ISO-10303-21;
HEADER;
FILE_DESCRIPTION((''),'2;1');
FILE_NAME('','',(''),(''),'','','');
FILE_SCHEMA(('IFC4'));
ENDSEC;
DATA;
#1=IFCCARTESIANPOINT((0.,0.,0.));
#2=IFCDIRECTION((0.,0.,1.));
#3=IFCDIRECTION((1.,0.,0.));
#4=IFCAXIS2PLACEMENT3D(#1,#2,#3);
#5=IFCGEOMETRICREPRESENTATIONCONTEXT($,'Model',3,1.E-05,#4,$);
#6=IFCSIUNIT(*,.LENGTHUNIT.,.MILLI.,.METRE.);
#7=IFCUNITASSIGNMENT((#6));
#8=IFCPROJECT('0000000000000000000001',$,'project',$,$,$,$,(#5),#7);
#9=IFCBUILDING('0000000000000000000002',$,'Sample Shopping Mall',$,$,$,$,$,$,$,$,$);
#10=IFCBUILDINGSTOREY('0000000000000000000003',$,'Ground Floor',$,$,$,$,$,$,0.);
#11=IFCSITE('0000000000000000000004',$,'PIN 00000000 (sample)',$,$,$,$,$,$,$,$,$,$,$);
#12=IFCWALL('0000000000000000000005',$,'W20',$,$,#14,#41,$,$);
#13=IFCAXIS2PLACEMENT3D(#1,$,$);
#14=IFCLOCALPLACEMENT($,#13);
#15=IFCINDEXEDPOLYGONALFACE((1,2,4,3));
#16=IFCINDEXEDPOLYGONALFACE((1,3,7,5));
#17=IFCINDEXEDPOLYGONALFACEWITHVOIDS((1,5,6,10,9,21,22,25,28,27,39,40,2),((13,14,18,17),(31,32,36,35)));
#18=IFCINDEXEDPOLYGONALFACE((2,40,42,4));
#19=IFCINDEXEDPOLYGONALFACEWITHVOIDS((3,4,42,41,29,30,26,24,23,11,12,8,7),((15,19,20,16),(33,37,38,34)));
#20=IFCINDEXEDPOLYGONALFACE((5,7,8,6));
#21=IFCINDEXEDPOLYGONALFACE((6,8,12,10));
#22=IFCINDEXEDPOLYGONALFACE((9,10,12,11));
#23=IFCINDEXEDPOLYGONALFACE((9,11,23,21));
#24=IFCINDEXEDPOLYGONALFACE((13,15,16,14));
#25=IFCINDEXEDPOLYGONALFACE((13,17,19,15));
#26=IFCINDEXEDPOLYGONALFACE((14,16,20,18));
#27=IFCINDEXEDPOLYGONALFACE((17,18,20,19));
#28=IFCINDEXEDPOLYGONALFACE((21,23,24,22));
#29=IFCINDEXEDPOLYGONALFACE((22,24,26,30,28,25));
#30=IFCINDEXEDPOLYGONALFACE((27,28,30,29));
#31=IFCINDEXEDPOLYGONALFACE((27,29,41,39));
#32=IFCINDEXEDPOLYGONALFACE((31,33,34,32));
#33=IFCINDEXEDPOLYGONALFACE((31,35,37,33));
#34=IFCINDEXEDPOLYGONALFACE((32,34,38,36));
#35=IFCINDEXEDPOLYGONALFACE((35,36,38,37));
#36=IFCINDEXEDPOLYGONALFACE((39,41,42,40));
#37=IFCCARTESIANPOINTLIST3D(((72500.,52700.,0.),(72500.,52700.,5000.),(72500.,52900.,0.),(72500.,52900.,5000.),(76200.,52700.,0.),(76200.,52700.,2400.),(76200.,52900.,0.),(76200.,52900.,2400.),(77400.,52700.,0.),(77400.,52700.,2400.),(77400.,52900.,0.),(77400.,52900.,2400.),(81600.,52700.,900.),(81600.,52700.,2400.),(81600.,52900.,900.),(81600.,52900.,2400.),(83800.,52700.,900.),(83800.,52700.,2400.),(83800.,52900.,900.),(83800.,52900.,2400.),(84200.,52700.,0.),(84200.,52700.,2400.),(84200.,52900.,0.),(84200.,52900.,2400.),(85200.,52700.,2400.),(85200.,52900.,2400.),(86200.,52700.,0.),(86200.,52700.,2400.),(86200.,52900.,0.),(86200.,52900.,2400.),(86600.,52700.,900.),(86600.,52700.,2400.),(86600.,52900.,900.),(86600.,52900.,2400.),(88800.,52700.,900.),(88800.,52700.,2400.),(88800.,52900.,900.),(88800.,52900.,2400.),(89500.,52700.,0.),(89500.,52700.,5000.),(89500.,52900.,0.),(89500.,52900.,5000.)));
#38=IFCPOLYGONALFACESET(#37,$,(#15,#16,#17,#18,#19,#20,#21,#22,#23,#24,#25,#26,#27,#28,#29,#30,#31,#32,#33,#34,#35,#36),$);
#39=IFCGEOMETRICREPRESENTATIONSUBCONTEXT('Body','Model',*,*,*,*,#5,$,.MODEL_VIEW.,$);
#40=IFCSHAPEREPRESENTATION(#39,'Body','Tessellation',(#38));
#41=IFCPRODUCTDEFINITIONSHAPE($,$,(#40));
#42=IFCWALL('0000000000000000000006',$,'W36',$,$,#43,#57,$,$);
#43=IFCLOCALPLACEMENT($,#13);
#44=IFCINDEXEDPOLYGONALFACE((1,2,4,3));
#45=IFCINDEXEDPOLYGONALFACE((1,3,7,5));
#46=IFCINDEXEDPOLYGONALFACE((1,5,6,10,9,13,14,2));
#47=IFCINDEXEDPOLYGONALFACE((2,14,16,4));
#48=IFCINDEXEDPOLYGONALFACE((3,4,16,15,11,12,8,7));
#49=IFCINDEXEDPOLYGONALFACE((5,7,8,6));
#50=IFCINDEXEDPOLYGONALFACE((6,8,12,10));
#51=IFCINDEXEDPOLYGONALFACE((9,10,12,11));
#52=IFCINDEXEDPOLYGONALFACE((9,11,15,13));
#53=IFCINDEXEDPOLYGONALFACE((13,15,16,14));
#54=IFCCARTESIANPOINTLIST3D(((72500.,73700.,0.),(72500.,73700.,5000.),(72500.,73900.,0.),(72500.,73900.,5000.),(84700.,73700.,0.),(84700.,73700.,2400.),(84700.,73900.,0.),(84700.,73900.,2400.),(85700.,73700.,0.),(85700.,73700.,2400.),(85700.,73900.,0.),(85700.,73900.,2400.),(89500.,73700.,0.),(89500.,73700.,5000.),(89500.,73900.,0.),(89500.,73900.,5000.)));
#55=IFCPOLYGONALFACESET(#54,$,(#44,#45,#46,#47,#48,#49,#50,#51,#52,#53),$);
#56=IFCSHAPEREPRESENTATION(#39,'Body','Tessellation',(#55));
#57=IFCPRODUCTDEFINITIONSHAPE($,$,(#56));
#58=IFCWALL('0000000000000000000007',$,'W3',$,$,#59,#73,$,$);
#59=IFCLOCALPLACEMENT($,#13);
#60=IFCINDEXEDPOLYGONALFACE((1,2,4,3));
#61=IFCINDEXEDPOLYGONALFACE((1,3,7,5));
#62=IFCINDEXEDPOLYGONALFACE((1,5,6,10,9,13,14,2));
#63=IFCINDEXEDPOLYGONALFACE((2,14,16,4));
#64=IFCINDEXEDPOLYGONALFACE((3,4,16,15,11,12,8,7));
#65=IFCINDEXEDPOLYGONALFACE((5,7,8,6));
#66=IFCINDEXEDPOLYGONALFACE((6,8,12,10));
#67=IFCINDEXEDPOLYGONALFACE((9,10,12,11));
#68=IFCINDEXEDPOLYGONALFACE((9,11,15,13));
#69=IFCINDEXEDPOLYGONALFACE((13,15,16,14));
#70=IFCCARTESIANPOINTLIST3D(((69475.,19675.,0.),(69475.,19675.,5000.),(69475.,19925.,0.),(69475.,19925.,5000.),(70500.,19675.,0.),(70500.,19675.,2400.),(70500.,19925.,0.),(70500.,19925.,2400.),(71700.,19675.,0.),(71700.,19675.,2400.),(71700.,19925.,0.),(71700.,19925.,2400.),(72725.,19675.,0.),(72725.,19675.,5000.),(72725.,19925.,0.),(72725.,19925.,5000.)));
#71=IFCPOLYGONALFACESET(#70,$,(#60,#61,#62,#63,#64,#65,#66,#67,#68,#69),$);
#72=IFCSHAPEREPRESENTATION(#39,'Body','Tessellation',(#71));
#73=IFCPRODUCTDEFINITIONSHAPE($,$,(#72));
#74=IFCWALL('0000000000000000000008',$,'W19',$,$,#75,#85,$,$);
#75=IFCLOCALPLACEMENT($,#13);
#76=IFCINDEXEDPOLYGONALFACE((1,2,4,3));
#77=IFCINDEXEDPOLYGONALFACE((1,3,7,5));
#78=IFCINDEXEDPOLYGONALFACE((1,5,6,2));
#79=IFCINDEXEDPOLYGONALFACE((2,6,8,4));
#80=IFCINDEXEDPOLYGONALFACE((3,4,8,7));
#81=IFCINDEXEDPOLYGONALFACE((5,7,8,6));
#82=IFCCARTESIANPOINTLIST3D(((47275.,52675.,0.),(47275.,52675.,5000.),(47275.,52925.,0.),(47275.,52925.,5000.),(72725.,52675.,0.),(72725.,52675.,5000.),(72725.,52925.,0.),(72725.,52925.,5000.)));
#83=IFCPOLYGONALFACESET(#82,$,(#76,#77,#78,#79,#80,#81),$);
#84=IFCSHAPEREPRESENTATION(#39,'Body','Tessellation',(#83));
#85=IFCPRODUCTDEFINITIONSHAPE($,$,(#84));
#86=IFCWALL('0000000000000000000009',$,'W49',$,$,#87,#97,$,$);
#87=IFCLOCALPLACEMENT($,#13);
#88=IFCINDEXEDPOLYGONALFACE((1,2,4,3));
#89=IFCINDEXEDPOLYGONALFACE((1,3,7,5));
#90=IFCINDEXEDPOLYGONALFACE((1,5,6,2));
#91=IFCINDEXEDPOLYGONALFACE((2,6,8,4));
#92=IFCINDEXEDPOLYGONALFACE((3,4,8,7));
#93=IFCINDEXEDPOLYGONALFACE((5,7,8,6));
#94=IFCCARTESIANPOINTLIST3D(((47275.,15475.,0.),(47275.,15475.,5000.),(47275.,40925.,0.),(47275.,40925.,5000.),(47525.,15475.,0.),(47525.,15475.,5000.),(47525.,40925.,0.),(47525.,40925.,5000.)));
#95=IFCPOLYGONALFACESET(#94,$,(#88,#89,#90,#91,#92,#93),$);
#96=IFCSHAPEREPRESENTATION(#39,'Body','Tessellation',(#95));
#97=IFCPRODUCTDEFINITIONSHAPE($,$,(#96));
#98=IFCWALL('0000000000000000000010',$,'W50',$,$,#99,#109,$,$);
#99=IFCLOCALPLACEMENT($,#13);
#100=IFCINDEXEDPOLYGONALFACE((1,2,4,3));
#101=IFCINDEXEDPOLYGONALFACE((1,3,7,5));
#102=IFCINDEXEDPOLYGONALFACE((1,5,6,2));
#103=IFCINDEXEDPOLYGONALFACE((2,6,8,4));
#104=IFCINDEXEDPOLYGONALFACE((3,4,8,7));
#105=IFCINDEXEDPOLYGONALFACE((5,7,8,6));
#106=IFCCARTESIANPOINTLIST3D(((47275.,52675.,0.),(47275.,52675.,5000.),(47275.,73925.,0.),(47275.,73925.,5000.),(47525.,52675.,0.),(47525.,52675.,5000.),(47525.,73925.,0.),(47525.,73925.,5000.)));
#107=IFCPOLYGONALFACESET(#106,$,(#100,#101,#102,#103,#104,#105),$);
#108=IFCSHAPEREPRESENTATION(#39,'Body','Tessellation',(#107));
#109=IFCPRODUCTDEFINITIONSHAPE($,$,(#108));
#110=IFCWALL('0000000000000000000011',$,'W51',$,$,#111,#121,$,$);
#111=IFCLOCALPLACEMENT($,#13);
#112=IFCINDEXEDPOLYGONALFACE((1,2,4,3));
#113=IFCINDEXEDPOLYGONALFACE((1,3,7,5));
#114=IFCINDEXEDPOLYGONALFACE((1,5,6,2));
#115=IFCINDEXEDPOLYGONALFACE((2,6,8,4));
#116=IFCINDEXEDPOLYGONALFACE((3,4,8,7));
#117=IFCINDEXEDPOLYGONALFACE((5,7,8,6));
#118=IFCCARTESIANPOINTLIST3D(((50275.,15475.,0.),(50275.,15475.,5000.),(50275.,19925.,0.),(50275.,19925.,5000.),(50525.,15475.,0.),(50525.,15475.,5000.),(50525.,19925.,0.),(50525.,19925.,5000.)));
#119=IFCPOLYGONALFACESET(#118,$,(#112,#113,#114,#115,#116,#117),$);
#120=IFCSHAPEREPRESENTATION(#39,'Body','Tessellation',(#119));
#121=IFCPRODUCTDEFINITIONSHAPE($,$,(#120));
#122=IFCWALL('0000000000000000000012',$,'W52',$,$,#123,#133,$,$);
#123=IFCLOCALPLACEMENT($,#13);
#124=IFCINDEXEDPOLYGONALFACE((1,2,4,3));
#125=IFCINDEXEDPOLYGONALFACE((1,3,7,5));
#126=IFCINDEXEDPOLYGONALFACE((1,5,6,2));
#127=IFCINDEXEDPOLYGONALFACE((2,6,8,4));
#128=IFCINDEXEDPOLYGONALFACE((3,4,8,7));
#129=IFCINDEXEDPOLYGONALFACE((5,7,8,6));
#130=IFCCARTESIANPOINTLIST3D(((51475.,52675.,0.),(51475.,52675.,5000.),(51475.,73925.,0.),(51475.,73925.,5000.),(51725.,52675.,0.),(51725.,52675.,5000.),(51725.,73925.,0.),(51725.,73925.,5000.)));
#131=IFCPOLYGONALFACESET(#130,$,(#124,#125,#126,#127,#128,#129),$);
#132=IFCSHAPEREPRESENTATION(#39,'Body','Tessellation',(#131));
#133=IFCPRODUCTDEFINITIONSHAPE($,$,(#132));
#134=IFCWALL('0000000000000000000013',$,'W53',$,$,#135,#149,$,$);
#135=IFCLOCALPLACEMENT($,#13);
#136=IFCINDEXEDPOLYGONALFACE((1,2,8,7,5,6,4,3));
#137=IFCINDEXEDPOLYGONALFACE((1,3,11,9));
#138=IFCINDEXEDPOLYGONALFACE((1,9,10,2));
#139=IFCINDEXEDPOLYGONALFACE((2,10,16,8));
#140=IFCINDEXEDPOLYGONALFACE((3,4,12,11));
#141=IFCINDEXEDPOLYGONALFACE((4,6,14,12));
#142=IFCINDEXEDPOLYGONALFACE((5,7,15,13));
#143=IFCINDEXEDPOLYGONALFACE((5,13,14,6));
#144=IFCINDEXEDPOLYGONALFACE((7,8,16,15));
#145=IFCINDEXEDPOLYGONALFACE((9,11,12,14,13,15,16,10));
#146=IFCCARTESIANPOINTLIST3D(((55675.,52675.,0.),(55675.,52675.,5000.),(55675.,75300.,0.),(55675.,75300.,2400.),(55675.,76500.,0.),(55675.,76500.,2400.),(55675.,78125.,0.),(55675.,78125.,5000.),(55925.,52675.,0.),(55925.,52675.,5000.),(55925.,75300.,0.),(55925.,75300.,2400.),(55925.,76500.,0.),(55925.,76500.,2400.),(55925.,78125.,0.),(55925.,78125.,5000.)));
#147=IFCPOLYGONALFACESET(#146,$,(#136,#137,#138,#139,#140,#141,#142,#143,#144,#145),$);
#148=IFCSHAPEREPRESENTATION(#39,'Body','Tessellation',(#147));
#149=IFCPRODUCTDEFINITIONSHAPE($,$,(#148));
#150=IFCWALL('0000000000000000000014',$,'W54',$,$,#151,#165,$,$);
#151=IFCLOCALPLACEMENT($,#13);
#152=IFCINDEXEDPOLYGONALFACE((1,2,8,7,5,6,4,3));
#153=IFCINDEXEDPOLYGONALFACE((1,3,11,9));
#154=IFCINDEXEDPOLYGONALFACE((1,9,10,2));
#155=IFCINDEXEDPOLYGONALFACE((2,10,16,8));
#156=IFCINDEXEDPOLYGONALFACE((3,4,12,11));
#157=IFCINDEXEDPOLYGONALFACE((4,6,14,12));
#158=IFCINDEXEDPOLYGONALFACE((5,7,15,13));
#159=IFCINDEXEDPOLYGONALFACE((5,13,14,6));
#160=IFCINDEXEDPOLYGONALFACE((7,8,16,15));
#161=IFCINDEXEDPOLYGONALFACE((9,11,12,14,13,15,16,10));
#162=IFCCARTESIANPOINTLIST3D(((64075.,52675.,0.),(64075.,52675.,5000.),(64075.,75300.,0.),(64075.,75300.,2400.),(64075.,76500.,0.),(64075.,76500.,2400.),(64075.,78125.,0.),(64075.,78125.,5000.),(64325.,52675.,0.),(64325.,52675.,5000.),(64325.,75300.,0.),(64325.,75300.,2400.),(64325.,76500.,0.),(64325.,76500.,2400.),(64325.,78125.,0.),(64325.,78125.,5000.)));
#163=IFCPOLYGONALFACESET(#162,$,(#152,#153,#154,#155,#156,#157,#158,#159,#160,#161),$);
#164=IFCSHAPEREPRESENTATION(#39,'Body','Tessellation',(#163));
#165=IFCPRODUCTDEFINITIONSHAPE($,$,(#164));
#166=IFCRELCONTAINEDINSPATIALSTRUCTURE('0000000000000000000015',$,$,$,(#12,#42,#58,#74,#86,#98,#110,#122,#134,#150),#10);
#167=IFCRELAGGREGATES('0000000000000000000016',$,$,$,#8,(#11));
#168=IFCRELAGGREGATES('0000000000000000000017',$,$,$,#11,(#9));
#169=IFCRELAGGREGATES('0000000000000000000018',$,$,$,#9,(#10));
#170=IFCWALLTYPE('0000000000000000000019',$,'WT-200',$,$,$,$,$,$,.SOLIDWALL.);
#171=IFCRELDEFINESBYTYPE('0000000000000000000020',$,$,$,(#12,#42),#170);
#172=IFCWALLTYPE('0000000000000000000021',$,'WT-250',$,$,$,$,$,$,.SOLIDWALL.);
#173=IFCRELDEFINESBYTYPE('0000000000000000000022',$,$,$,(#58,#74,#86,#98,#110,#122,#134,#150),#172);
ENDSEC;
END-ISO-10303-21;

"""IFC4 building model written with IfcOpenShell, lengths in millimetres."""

from ifc_helpers import new_model, si_unit, frame, origin_with_axes, place, context, subcontext, project, spatial, indexed_curve, outline, extrude, type_object, element, save


model = new_model("IFC4")

# Units and contexts
model_context = context("Model", 3, precision=1e-05, world=origin_with_axes())
body_context = subcontext(model_context, "Body", "Model", "MODEL_VIEW")
ifc_project = project(units=[si_unit("LENGTHUNIT", "METRE", prefix="MILLI")], contexts=[model_context])

# Site, building, storey
site = spatial("IfcSite", under=ifc_project, Name="PIN 00000000 (sample)")
building = spatial("IfcBuilding", under=site, Name="Sample Shopping Mall")
storey = spatial("IfcBuildingStorey", under=building, Name="Ground Floor", Elevation=0.0)

# Wall, openings
wall_type_1 = type_object("IfcWallType", Name="WT-200", PredefinedType="SOLIDWALL")
wall_1_placement = place(None, frame((72500.0, 52700.0, 0.0), z_axis=(0.0, 0.0, 1.0), x_axis=(1.0, 0.0, 0.0)))
wall_1 = element("IfcWall", 1, at=wall_1_placement, inside=storey, type_object=wall_type_1, Name="W20", context=body_context, shape_type="SweptSolid", body=[
    extrude(outline(indexed_curve([(0.0, 0.0), (0.0, 200.0), (17000.0, 200.0), (17000.0, 0.0), (0.0, 0.0)], self_intersect=False)), origin_with_axes(), (0.0, 0.0, 1.0), 5000.0),
])
opening_1_placement = place(wall_1_placement, frame((3700.0, -100.0, 0.0), z_axis=(0.0, 0.0, 1.0), x_axis=(1.0, 0.0, 0.0)))
element("IfcOpeningElement", 2, at=opening_1_placement, cuts=wall_1, context=body_context, shape_type="SweptSolid", body=[
    extrude(outline(indexed_curve([(0.0, 0.0), (0.0, 400.0), (1200.0, 400.0), (1200.0, 0.0), (0.0, 0.0)], self_intersect=False)), origin_with_axes(), (0.0, 0.0, 1.0), 2400.0),
])
opening_2_placement = place(wall_1_placement, frame((11700.0, -100.0, 0.0), z_axis=(0.0, 0.0, 1.0), x_axis=(1.0, 0.0, 0.0)))
element("IfcOpeningElement", 3, at=opening_2_placement, cuts=wall_1, context=body_context, shape_type="SweptSolid", body=[
    extrude(outline(indexed_curve([(0.0, 0.0), (0.0, 400.0), (1000.0, 400.0), (1000.0, 0.0), (0.0, 0.0)], self_intersect=False)), origin_with_axes(), (0.0, 0.0, 1.0), 2400.0),
])
opening_3_placement = place(wall_1_placement, frame((12700.0, -100.0, 0.0), z_axis=(0.0, 0.0, 1.0), x_axis=(1.0, 0.0, 0.0)))
element("IfcOpeningElement", 4, at=opening_3_placement, cuts=wall_1, context=body_context, shape_type="SweptSolid", body=[
    extrude(outline(indexed_curve([(0.0, 0.0), (0.0, 400.0), (1000.0, 400.0), (1000.0, 0.0), (0.0, 0.0)], self_intersect=False)), origin_with_axes(), (0.0, 0.0, 1.0), 2400.0),
])
opening_4_placement = place(wall_1_placement, frame((9100.0, -100.0, 900.0), z_axis=(0.0, 0.0, 1.0), x_axis=(1.0, 0.0, 0.0)))
element("IfcOpeningElement", 5, at=opening_4_placement, cuts=wall_1, context=body_context, shape_type="SweptSolid", body=[
    extrude(outline(indexed_curve([(0.0, 0.0), (0.0, 400.0), (2200.0, 400.0), (2200.0, 0.0), (0.0, 0.0)], self_intersect=False)), origin_with_axes(), (0.0, 0.0, 1.0), 1500.0),
])
opening_5_placement = place(wall_1_placement, frame((14100.0, -100.0, 900.0), z_axis=(0.0, 0.0, 1.0), x_axis=(1.0, 0.0, 0.0)))
element("IfcOpeningElement", 6, at=opening_5_placement, cuts=wall_1, context=body_context, shape_type="SweptSolid", body=[
    extrude(outline(indexed_curve([(0.0, 0.0), (0.0, 400.0), (2200.0, 400.0), (2200.0, 0.0), (0.0, 0.0)], self_intersect=False)), origin_with_axes(), (0.0, 0.0, 1.0), 1500.0),
])

# Walls, openings
wall_2_placement = place(None, frame((72500.0, 73700.0, 0.0), z_axis=(0.0, 0.0, 1.0), x_axis=(1.0, 0.0, 0.0)))
wall_2 = element("IfcWall", 7, at=wall_2_placement, inside=storey, type_object=wall_type_1, Name="W36", context=body_context, shape_type="SweptSolid", body=[
    extrude(outline(indexed_curve([(0.0, 0.0), (0.0, 200.0), (17000.0, 200.0), (17000.0, 0.0), (0.0, 0.0)], self_intersect=False)), origin_with_axes(), (0.0, 0.0, 1.0), 5000.0),
])
opening_6_placement = place(wall_2_placement, frame((12200.0, -100.0, 0.0), z_axis=(0.0, 0.0, 1.0), x_axis=(1.0, 0.0, 0.0)))
element("IfcOpeningElement", 8, at=opening_6_placement, cuts=wall_2, context=body_context, shape_type="SweptSolid", body=[
    extrude(outline(indexed_curve([(0.0, 0.0), (0.0, 400.0), (1000.0, 400.0), (1000.0, 0.0), (0.0, 0.0)], self_intersect=False)), origin_with_axes(), (0.0, 0.0, 1.0), 2400.0),
])
wall_type_2 = type_object("IfcWallType", Name="WT-250", PredefinedType="SOLIDWALL")
wall_3_placement = place(None, frame((69475.0, 19675.0, 0.0), z_axis=(0.0, 0.0, 1.0), x_axis=(1.0, 0.0, 0.0)))
wall_3 = element("IfcWall", 9, at=wall_3_placement, inside=storey, type_object=wall_type_2, Name="W3", context=body_context, shape_type="SweptSolid", body=[
    extrude(outline(indexed_curve([(0.0, 0.0), (0.0, 250.0), (3250.0, 250.0), (3250.0, 0.0), (0.0, 0.0)], self_intersect=False)), origin_with_axes(), (0.0, 0.0, 1.0), 5000.0),
])
opening_7_placement = place(wall_3_placement, frame((1025.0, -100.0, 0.0), z_axis=(0.0, 0.0, 1.0), x_axis=(1.0, 0.0, 0.0)))
element("IfcOpeningElement", 10, at=opening_7_placement, cuts=wall_3, context=body_context, shape_type="SweptSolid", body=[
    extrude(outline(indexed_curve([(0.0, 0.0), (0.0, 450.0), (1200.0, 450.0), (1200.0, 0.0), (0.0, 0.0)], self_intersect=False)), origin_with_axes(), (0.0, 0.0, 1.0), 2400.0),
])

# Wall
wall_4_placement = place(None, frame((47275.0, 52675.0, 0.0), z_axis=(0.0, 0.0, 1.0), x_axis=(1.0, 0.0, 0.0)))
element("IfcWall", 11, at=wall_4_placement, inside=storey, type_object=wall_type_2, Name="W19", context=body_context, shape_type="SweptSolid", body=[
    extrude(outline(indexed_curve([(0.0, 0.0), (0.0, 250.0), (25450.0, 250.0), (25450.0, 0.0), (0.0, 0.0)], self_intersect=False)), origin_with_axes(), (0.0, 0.0, 1.0), 5000.0),
])

# Walls
wall_5_placement = place(None, frame((47525.0, 15475.0, 0.0), z_axis=(0.0, 0.0, 1.0), x_axis=(0.0, 1.0, 0.0)))
element("IfcWall", 12, at=wall_5_placement, inside=storey, type_object=wall_type_2, Name="W49", context=body_context, shape_type="SweptSolid", body=[
    extrude(outline(indexed_curve([(0.0, 0.0), (0.0, 250.0), (25450.0, 250.0), (25450.0, 0.0), (0.0, 0.0)], self_intersect=False)), origin_with_axes(), (0.0, 0.0, 1.0), 5000.0),
])
wall_6_placement = place(None, frame((47525.0, 52675.0, 0.0), z_axis=(0.0, 0.0, 1.0), x_axis=(0.0, 1.0, 0.0)))
element("IfcWall", 13, at=wall_6_placement, inside=storey, type_object=wall_type_2, Name="W50", context=body_context, shape_type="SweptSolid", body=[
    extrude(outline(indexed_curve([(0.0, 0.0), (0.0, 250.0), (21250.0, 250.0), (21250.0, 0.0), (0.0, 0.0)], self_intersect=False)), origin_with_axes(), (0.0, 0.0, 1.0), 5000.0),
])
wall_7_placement = place(None, frame((50525.0, 15475.0, 0.0), z_axis=(0.0, 0.0, 1.0), x_axis=(0.0, 1.0, 0.0)))
element("IfcWall", 14, at=wall_7_placement, inside=storey, type_object=wall_type_2, Name="W51", context=body_context, shape_type="SweptSolid", body=[
    extrude(outline(indexed_curve([(0.0, 0.0), (0.0, 250.0), (4450.0, 250.0), (4450.0, 0.0), (0.0, 0.0)], self_intersect=False)), origin_with_axes(), (0.0, 0.0, 1.0), 5000.0),
])
wall_8_placement = place(None, frame((51725.0, 52675.0, 0.0), z_axis=(0.0, 0.0, 1.0), x_axis=(0.0, 1.0, 0.0)))
element("IfcWall", 15, at=wall_8_placement, inside=storey, type_object=wall_type_2, Name="W52", context=body_context, shape_type="SweptSolid", body=[
    extrude(outline(indexed_curve([(0.0, 0.0), (0.0, 250.0), (21250.0, 250.0), (21250.0, 0.0), (0.0, 0.0)], self_intersect=False)), origin_with_axes(), (0.0, 0.0, 1.0), 5000.0),
])

# Walls, openings
wall_9_placement = place(None, frame((55925.0, 52675.0, 0.0), z_axis=(0.0, 0.0, 1.0), x_axis=(0.0, 1.0, 0.0)))
wall_9 = element("IfcWall", 16, at=wall_9_placement, inside=storey, type_object=wall_type_2, Name="W53", context=body_context, shape_type="SweptSolid", body=[
    extrude(outline(indexed_curve([(0.0, 0.0), (0.0, 250.0), (25450.0, 250.0), (25450.0, 0.0), (0.0, 0.0)], self_intersect=False)), origin_with_axes(), (0.0, 0.0, 1.0), 5000.0),
])
opening_8_placement = place(wall_9_placement, frame((22625.0, -100.0, 0.0), z_axis=(0.0, 0.0, 1.0), x_axis=(1.0, 0.0, 0.0)))
element("IfcOpeningElement", 17, at=opening_8_placement, cuts=wall_9, context=body_context, shape_type="SweptSolid", body=[
    extrude(outline(indexed_curve([(0.0, 0.0), (0.0, 450.0), (1200.0, 450.0), (1200.0, 0.0), (0.0, 0.0)], self_intersect=False)), origin_with_axes(), (0.0, 0.0, 1.0), 2400.0),
])
wall_10_placement = place(None, frame((64325.0, 52675.0, 0.0), z_axis=(0.0, 0.0, 1.0), x_axis=(0.0, 1.0, 0.0)))
wall_10 = element("IfcWall", 18, at=wall_10_placement, inside=storey, type_object=wall_type_2, Name="W54", context=body_context, shape_type="SweptSolid", body=[
    extrude(outline(indexed_curve([(0.0, 0.0), (0.0, 250.0), (25450.0, 250.0), (25450.0, 0.0), (0.0, 0.0)], self_intersect=False)), origin_with_axes(), (0.0, 0.0, 1.0), 5000.0),
])
opening_9_placement = place(wall_10_placement, frame((22625.0, -100.0, 0.0), z_axis=(0.0, 0.0, 1.0), x_axis=(1.0, 0.0, 0.0)))
element("IfcOpeningElement", 19, at=opening_9_placement, cuts=wall_10, context=body_context, shape_type="SweptSolid", body=[
    extrude(outline(indexed_curve([(0.0, 0.0), (0.0, 450.0), (1200.0, 450.0), (1200.0, 0.0), (0.0, 0.0)], self_intersect=False)), origin_with_axes(), (0.0, 0.0, 1.0), 2400.0),
])

save(model, "model.ifc")
